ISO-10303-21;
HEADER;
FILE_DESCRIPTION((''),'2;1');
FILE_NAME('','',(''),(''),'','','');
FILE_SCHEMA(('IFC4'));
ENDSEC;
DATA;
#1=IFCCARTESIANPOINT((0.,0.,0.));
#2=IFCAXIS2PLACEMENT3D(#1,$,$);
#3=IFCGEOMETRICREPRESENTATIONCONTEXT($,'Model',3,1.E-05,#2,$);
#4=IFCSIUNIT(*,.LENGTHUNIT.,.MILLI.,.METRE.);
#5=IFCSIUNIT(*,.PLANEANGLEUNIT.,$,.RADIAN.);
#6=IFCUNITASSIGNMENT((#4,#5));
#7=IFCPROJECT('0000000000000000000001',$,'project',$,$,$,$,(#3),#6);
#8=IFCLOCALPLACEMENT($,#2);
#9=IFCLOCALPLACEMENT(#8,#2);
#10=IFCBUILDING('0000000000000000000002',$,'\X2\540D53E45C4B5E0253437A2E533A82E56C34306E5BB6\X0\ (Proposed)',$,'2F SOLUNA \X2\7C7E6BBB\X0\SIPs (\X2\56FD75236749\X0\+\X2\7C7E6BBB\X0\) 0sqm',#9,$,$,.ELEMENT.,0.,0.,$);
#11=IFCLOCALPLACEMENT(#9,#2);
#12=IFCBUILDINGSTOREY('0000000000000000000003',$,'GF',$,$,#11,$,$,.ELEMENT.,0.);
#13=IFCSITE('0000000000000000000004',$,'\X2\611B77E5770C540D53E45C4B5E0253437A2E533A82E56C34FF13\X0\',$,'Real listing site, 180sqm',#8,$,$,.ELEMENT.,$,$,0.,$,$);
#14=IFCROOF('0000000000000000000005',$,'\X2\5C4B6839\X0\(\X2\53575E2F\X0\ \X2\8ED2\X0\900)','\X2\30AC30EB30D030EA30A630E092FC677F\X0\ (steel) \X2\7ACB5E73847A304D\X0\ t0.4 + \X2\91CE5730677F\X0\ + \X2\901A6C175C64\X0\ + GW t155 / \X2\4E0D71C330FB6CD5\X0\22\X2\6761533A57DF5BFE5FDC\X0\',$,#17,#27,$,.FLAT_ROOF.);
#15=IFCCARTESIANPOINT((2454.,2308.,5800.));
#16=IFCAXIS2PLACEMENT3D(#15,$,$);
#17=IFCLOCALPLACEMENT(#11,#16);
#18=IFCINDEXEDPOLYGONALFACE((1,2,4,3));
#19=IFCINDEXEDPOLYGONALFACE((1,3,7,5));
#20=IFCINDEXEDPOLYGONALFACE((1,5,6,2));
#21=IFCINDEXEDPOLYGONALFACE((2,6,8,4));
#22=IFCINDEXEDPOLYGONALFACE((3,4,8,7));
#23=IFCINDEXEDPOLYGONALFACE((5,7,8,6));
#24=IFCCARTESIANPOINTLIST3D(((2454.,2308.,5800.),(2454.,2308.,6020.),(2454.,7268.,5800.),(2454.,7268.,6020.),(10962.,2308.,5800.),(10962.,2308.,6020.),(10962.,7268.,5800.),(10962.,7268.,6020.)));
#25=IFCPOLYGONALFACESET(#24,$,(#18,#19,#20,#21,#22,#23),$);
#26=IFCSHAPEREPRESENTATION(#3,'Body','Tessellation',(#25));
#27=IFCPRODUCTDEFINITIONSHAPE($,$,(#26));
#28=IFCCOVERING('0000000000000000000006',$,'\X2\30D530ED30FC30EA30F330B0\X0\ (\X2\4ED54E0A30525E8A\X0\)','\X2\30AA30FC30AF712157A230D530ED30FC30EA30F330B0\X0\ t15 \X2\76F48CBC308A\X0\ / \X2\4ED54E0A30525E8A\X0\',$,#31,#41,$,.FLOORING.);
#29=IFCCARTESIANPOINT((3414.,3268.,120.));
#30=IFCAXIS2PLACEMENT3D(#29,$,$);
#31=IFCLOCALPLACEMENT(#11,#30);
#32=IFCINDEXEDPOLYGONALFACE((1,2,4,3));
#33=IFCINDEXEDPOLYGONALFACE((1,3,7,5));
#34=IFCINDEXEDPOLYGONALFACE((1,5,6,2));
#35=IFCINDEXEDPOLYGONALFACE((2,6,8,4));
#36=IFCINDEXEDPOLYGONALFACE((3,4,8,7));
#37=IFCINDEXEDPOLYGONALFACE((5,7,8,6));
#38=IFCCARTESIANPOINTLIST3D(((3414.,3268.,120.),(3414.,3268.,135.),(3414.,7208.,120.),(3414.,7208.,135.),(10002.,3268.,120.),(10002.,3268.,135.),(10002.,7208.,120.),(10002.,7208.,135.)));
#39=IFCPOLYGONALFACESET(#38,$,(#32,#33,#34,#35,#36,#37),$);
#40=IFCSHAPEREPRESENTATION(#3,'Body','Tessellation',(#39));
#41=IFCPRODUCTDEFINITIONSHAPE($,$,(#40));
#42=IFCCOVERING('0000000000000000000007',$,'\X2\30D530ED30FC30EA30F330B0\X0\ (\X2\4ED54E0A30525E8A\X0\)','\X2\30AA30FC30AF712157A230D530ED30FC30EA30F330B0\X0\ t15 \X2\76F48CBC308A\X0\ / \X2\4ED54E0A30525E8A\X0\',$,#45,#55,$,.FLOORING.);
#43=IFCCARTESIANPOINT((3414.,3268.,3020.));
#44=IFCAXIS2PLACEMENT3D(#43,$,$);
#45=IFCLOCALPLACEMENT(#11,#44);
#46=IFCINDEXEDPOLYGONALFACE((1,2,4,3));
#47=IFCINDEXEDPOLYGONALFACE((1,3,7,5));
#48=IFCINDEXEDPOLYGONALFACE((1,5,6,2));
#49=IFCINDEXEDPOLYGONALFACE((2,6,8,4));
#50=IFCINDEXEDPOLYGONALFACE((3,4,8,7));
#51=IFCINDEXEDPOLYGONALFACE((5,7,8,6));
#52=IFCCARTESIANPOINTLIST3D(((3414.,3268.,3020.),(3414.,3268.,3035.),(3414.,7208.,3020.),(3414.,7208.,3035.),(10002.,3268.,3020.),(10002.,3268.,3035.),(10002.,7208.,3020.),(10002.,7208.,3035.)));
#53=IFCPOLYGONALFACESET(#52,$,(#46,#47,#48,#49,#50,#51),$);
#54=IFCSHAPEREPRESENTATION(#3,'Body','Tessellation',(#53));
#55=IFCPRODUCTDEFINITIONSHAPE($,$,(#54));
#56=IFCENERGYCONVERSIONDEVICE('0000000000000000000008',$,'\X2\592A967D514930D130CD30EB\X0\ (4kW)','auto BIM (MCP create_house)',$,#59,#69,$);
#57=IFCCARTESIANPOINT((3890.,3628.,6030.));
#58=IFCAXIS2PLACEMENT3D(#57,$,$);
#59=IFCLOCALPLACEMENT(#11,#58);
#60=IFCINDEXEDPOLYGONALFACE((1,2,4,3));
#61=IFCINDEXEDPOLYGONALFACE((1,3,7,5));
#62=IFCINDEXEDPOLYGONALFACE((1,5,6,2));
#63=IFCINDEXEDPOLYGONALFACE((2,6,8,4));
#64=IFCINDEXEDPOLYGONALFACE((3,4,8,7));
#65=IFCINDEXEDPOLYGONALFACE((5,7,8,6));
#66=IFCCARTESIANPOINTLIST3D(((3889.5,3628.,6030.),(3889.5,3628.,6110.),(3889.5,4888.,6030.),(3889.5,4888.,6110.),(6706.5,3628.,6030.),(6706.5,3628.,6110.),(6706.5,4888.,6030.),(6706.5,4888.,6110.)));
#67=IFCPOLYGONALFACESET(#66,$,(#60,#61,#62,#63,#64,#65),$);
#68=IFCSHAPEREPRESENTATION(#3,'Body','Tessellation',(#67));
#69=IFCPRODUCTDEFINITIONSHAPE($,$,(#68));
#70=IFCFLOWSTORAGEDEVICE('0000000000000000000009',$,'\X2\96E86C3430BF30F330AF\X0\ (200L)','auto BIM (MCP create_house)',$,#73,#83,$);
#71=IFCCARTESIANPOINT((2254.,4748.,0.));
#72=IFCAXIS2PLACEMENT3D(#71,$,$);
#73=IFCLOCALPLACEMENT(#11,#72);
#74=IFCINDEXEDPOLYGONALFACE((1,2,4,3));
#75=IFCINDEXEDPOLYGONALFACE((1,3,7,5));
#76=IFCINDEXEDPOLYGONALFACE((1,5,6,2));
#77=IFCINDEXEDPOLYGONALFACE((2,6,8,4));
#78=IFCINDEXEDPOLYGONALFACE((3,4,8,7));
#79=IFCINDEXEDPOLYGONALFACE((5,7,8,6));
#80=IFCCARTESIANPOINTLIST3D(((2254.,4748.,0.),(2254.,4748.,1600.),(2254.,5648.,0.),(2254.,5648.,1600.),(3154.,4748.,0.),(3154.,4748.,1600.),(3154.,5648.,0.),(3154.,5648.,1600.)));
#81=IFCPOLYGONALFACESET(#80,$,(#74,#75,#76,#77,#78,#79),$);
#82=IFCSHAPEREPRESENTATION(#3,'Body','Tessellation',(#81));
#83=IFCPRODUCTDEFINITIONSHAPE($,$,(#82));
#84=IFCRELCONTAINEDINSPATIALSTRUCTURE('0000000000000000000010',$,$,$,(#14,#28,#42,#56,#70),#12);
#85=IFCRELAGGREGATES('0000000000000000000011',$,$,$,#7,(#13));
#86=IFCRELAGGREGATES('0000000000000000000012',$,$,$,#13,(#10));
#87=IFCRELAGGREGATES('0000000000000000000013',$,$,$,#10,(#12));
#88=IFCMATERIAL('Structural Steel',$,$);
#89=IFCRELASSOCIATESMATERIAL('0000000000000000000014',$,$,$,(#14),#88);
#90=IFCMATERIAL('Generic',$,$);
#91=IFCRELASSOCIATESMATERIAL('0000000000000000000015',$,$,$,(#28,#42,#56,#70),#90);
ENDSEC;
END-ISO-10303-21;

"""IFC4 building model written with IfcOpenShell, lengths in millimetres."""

from ifc_helpers import new_model, si_unit, frame, frame_2d, origin, place, context, project, spatial, rectangle, extrude, material, element, save


model = new_model("IFC4")

# Units and contexts
model_context = context("Model", 3, precision=1e-05, world=origin())
ifc_project = project(units=[si_unit("LENGTHUNIT", "METRE", prefix="MILLI"), si_unit("PLANEANGLEUNIT", "RADIAN")], contexts=[model_context])

# Site, building, storey
site_placement = place(None, origin())
site = spatial("IfcSite", under=ifc_project, at=site_placement, Name="愛知県名古屋市千種区若水３", ObjectType="Real listing site, 180sqm", CompositionType="ELEMENT", RefElevation=0.0)
building_placement = place(site_placement, origin())
building = spatial("IfcBuilding", under=site, at=building_placement, Name="名古屋市千種区若水の家 (Proposed)", ObjectType="2F SOLUNA 籾殻SIPs (国産杉+籾殻) 0sqm", CompositionType="ELEMENT", ElevationOfRefHeight=0.0, ElevationOfTerrain=0.0)
storey_placement = place(building_placement, origin())
storey = spatial("IfcBuildingStorey", under=building, at=storey_placement, Name="GF", CompositionType="ELEMENT", Elevation=0.0)

# Roof
ifc_material_1 = material(Name="Structural Steel")
for number, where, name in (
    (1, (2454.0, 2308.0, 5800.0), "屋根(南帯 軒900)"),
):
    element("IfcRoof", number, at=place(storey_placement, frame(where)), inside=storey, material=ifc_material_1, Name=name, Description="ガルバリウム鋼板 (steel) 立平葺き t0.4 + 野地板 + 通気層 + GW t155 / 不燃・法22条区域対応", PredefinedType="FLAT_ROOF", context=model_context, shape_type="SweptSolid", body=[
        extrude(rectangle(XDim=8508.0, YDim=4960.0, at=frame_2d((4254.0, 2480.0))), frame((2454.0, 2308.0, 5800.0)), (0.0, 0.0, 1.0), 220.0),
    ])

# Coverings
ifc_material_2 = material(Name="Generic")
covering_1_placement = place(storey_placement, frame((3414.0, 3268.0, 120.0)))
element("IfcCovering", 2, at=covering_1_placement, inside=storey, material=ifc_material_2, Name="フローリング (仕上げ床)", Description="オーク無垢フローリング t15 直貼り / 仕上げ床", PredefinedType="FLOORING", context=model_context, shape_type="SweptSolid", body=[
    extrude(rectangle(XDim=6588.0, YDim=3940.0, at=frame_2d((3294.0, 1970.0))), frame((3414.0, 3268.0, 120.0)), (0.0, 0.0, 1.0), 15.0),
])
covering_2_placement = place(storey_placement, frame((3414.0, 3268.0, 3020.0)))
element("IfcCovering", 3, at=covering_2_placement, inside=storey, material=ifc_material_2, Name="フローリング (仕上げ床)", Description="オーク無垢フローリング t15 直貼り / 仕上げ床", PredefinedType="FLOORING", context=model_context, shape_type="SweptSolid", body=[
    extrude(rectangle(XDim=6588.0, YDim=3940.0, at=frame_2d((3294.0, 1970.0))), frame((3414.0, 3268.0, 3020.0)), (0.0, 0.0, 1.0), 15.0),
])

# Energy conversion device
energy_conversion_device_placement = place(storey_placement, frame((3890.0, 3628.0, 6030.0)))
element("IfcEnergyConversionDevice", 4, at=energy_conversion_device_placement, inside=storey, material=ifc_material_2, Name="太陽光パネル (4kW)", Description="auto BIM (MCP create_house)", context=model_context, shape_type="SweptSolid", body=[
    extrude(rectangle(XDim=2817.0, YDim=1260.0, at=frame_2d((1408.0, 630.0))), frame((3890.0, 3628.0, 6030.0)), (0.0, 0.0, 1.0), 80.0),
])

# Flow storage device
flow_storage_device_placement = place(storey_placement, frame((2254.0, 4748.0, 0.0)))
element("IfcFlowStorageDevice", 5, at=flow_storage_device_placement, inside=storey, material=ifc_material_2, Name="雨水タンク (200L)", Description="auto BIM (MCP create_house)", context=model_context, shape_type="SweptSolid", body=[
    extrude(rectangle(XDim=900.0, YDim=900.0, at=frame_2d((450.0, 450.0))), frame((2254.0, 4748.0, 0.0)), (0.0, 0.0, 1.0), 1600.0),
])

save(model, "model.ifc")
